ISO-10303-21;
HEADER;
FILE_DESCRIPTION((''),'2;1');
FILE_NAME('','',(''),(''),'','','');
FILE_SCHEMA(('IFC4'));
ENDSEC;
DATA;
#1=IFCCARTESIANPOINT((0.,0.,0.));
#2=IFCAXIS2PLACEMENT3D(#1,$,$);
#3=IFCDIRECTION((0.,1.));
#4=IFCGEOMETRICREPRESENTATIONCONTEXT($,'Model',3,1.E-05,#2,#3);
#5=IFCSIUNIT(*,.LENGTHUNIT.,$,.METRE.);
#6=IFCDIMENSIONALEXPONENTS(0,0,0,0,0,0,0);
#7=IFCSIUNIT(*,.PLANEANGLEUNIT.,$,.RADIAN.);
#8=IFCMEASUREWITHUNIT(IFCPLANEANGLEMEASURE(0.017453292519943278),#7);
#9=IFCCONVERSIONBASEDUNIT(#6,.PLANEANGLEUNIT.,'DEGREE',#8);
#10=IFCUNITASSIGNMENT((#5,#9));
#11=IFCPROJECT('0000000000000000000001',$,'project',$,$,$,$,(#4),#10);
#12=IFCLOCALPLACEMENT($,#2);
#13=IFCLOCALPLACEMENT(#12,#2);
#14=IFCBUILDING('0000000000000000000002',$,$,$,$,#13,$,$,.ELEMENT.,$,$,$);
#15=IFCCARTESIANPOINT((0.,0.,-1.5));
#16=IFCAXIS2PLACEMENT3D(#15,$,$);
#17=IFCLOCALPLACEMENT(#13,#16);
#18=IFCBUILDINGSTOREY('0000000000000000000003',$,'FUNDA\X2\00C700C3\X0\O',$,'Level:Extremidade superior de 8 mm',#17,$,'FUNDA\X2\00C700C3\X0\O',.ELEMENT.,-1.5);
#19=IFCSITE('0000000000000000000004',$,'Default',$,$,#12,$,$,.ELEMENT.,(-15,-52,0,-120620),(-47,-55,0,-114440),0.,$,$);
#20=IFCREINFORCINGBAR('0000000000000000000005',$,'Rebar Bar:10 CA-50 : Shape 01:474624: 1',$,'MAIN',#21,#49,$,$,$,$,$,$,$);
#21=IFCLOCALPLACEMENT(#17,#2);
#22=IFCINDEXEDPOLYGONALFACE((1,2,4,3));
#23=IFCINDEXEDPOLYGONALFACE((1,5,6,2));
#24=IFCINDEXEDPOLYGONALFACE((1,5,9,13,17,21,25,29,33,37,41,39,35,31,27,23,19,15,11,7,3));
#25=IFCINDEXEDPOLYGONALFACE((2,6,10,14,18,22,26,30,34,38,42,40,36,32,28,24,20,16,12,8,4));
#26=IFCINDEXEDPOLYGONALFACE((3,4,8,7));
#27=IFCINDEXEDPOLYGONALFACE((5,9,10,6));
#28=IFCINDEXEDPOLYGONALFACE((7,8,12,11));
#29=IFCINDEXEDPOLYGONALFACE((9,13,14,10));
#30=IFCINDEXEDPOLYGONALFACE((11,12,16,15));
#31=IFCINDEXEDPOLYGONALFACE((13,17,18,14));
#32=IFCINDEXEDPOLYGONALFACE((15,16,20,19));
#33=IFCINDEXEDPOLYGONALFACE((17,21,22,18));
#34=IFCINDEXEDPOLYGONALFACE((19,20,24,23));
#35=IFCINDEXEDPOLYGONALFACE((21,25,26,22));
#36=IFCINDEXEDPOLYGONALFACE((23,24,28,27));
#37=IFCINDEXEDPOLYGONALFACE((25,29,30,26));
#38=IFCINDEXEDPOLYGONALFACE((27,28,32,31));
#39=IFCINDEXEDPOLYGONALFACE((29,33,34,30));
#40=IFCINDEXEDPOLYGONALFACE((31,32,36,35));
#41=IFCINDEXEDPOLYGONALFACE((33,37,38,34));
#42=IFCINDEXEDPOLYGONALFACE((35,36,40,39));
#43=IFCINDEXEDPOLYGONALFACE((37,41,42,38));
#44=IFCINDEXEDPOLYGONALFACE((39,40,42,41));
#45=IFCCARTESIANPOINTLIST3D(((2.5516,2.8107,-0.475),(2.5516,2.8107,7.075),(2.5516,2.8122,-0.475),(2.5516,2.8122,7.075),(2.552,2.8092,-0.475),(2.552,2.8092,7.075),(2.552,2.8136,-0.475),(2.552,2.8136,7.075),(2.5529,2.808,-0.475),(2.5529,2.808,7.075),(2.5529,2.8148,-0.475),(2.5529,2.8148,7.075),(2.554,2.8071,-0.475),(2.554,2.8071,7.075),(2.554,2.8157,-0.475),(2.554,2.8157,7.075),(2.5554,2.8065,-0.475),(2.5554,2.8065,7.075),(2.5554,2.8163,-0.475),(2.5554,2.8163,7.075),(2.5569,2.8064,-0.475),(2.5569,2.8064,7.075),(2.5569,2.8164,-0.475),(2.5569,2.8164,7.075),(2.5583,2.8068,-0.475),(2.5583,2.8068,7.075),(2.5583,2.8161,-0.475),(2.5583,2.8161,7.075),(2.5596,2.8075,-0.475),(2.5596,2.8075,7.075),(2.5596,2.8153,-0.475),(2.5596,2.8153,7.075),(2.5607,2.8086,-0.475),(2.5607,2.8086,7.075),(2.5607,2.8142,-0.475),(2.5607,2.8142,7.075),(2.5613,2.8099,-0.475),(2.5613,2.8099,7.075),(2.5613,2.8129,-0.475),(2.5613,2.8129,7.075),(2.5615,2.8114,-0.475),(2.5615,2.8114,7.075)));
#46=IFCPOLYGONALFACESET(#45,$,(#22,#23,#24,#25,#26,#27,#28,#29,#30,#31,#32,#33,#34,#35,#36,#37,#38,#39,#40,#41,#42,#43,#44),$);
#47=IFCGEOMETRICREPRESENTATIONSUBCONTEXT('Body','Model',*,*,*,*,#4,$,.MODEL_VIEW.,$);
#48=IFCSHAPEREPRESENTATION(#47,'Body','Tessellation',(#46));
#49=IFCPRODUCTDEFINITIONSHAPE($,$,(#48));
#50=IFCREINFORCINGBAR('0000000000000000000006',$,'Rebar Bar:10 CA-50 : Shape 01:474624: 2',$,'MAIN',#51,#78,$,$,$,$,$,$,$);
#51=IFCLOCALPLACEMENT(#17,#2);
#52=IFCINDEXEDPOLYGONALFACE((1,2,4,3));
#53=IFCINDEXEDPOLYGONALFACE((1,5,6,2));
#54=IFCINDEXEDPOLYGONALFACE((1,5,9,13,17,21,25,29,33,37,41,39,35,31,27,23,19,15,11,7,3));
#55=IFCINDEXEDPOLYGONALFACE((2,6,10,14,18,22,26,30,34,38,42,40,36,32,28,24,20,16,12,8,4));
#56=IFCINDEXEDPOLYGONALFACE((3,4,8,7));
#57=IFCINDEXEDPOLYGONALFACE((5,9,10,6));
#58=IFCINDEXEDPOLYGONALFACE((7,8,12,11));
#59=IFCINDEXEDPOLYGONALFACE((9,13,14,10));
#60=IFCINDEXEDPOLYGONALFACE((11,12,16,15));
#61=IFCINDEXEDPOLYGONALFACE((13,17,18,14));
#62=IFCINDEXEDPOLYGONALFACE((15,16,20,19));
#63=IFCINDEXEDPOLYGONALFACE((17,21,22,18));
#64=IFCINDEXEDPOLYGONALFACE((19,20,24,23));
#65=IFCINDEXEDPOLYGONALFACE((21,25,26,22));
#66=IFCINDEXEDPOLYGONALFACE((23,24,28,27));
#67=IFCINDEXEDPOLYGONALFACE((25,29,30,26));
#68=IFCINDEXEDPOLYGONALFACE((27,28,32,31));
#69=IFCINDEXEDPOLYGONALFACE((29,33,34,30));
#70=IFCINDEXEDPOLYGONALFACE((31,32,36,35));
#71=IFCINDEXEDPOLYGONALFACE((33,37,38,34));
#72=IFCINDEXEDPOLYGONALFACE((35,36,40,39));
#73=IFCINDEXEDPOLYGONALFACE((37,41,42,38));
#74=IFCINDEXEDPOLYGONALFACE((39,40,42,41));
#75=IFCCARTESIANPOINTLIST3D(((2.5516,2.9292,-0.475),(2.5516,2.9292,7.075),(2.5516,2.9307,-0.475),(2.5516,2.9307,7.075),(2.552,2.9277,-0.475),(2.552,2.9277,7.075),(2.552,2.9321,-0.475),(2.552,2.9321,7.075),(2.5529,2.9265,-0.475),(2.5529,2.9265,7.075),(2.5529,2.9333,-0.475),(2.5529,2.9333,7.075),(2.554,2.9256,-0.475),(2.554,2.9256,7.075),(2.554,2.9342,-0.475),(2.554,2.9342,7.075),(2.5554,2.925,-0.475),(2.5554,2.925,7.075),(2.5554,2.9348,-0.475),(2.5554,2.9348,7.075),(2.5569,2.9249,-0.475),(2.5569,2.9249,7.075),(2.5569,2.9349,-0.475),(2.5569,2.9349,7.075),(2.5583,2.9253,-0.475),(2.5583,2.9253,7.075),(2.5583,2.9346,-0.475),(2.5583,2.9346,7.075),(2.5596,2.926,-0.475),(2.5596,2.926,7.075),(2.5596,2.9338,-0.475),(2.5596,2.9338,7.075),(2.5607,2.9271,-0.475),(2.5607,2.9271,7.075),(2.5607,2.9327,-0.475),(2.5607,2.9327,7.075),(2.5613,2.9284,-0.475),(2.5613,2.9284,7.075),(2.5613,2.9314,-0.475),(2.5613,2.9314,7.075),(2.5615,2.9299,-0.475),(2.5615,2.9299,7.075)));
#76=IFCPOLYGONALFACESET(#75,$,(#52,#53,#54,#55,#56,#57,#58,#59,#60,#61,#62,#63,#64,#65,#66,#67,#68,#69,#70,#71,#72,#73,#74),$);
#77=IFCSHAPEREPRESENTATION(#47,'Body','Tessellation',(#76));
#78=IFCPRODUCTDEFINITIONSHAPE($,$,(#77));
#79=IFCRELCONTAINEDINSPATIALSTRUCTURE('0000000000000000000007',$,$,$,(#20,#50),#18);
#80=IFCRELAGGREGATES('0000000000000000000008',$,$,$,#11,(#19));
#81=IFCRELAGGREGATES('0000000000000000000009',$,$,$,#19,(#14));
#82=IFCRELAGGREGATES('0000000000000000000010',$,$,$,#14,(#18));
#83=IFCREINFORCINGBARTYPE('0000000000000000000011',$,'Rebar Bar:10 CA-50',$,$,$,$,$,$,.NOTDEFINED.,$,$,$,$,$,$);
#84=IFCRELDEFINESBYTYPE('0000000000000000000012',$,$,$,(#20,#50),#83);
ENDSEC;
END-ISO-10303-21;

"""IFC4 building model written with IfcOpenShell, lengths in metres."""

from ifc_helpers import new_model, entity, si_unit, converted_unit, direction, frame, origin, place, context, subcontext, project, spatial, type_object, element, save


model = new_model("IFC4")

# Units and contexts
model_context = context("Model", 3, precision=1e-05, world=origin(), true_north=direction((0.0, 1.0)))
body_context = subcontext(model_context, "Body", "Model", "MODEL_VIEW")
ifc_project = project(units=[si_unit("LENGTHUNIT", "METRE"), converted_unit("PLANEANGLEUNIT", "DEGREE", entity("IfcPlaneAngleMeasure", 0.017453292519943278), si_unit("PLANEANGLEUNIT", "RADIAN"), dimensions=[0, 0, 0, 0, 0, 0, 0])], contexts=[model_context])

# Site, building, storey
site_placement = place(None, origin())
site = spatial("IfcSite", under=ifc_project, at=site_placement, Name="Default", CompositionType="ELEMENT", RefLatitude=(-15, -52, 0, -120620), RefLongitude=(-47, -55, 0, -114440), RefElevation=0.0)
building_placement = place(site_placement, origin())
building = spatial("IfcBuilding", under=site, at=building_placement, CompositionType="ELEMENT")
storey_placement = place(building_placement, frame((0.0, 0.0, -1.5)))
storey = spatial("IfcBuildingStorey", under=building, at=storey_placement, Name="FUNDAÇÃO", ObjectType="Level:Extremidade superior de 8 mm", LongName="FUNDAÇÃO", CompositionType="ELEMENT", Elevation=-1.5)

# Reinforcing bars
reinforcing_bar_type_1 = type_object("IfcReinforcingBarType", Name="Rebar Bar:10 CA-50", PredefinedType="NOTDEFINED")
reinforcing_bar_1_placement = place(storey_placement, origin())
element("IfcReinforcingBar", 1, at=reinforcing_bar_1_placement, inside=storey, type_object=reinforcing_bar_type_1, Name="Rebar Bar:10 CA-50 : Shape 01:474624: 1", ObjectType="MAIN", context=body_context, shape_type="AdvancedSweptSolid", body=[
    entity("IfcSweptDiskSolid", entity("IfcIndexedPolyCurve", entity("IfcCartesianPointList3D", [[2.5565, 2.8114, -0.475], [2.5565, 2.8114, 7.075]]), None, False), 0.005, None, 0.0, 1.0),
])
reinforcing_bar_2_placement = place(storey_placement, origin())
element("IfcReinforcingBar", 2, at=reinforcing_bar_2_placement, inside=storey, type_object=reinforcing_bar_type_1, Name="Rebar Bar:10 CA-50 : Shape 01:474624: 2", ObjectType="MAIN", context=body_context, shape_type="AdvancedSweptSolid", body=[
    entity("IfcSweptDiskSolid", entity("IfcIndexedPolyCurve", entity("IfcCartesianPointList3D", [[2.5565, 2.9299, -0.475], [2.5565, 2.9299, 7.075]]), None, False), 0.005, None, 0.0, 1.0),
])

save(model, "model.ifc")
